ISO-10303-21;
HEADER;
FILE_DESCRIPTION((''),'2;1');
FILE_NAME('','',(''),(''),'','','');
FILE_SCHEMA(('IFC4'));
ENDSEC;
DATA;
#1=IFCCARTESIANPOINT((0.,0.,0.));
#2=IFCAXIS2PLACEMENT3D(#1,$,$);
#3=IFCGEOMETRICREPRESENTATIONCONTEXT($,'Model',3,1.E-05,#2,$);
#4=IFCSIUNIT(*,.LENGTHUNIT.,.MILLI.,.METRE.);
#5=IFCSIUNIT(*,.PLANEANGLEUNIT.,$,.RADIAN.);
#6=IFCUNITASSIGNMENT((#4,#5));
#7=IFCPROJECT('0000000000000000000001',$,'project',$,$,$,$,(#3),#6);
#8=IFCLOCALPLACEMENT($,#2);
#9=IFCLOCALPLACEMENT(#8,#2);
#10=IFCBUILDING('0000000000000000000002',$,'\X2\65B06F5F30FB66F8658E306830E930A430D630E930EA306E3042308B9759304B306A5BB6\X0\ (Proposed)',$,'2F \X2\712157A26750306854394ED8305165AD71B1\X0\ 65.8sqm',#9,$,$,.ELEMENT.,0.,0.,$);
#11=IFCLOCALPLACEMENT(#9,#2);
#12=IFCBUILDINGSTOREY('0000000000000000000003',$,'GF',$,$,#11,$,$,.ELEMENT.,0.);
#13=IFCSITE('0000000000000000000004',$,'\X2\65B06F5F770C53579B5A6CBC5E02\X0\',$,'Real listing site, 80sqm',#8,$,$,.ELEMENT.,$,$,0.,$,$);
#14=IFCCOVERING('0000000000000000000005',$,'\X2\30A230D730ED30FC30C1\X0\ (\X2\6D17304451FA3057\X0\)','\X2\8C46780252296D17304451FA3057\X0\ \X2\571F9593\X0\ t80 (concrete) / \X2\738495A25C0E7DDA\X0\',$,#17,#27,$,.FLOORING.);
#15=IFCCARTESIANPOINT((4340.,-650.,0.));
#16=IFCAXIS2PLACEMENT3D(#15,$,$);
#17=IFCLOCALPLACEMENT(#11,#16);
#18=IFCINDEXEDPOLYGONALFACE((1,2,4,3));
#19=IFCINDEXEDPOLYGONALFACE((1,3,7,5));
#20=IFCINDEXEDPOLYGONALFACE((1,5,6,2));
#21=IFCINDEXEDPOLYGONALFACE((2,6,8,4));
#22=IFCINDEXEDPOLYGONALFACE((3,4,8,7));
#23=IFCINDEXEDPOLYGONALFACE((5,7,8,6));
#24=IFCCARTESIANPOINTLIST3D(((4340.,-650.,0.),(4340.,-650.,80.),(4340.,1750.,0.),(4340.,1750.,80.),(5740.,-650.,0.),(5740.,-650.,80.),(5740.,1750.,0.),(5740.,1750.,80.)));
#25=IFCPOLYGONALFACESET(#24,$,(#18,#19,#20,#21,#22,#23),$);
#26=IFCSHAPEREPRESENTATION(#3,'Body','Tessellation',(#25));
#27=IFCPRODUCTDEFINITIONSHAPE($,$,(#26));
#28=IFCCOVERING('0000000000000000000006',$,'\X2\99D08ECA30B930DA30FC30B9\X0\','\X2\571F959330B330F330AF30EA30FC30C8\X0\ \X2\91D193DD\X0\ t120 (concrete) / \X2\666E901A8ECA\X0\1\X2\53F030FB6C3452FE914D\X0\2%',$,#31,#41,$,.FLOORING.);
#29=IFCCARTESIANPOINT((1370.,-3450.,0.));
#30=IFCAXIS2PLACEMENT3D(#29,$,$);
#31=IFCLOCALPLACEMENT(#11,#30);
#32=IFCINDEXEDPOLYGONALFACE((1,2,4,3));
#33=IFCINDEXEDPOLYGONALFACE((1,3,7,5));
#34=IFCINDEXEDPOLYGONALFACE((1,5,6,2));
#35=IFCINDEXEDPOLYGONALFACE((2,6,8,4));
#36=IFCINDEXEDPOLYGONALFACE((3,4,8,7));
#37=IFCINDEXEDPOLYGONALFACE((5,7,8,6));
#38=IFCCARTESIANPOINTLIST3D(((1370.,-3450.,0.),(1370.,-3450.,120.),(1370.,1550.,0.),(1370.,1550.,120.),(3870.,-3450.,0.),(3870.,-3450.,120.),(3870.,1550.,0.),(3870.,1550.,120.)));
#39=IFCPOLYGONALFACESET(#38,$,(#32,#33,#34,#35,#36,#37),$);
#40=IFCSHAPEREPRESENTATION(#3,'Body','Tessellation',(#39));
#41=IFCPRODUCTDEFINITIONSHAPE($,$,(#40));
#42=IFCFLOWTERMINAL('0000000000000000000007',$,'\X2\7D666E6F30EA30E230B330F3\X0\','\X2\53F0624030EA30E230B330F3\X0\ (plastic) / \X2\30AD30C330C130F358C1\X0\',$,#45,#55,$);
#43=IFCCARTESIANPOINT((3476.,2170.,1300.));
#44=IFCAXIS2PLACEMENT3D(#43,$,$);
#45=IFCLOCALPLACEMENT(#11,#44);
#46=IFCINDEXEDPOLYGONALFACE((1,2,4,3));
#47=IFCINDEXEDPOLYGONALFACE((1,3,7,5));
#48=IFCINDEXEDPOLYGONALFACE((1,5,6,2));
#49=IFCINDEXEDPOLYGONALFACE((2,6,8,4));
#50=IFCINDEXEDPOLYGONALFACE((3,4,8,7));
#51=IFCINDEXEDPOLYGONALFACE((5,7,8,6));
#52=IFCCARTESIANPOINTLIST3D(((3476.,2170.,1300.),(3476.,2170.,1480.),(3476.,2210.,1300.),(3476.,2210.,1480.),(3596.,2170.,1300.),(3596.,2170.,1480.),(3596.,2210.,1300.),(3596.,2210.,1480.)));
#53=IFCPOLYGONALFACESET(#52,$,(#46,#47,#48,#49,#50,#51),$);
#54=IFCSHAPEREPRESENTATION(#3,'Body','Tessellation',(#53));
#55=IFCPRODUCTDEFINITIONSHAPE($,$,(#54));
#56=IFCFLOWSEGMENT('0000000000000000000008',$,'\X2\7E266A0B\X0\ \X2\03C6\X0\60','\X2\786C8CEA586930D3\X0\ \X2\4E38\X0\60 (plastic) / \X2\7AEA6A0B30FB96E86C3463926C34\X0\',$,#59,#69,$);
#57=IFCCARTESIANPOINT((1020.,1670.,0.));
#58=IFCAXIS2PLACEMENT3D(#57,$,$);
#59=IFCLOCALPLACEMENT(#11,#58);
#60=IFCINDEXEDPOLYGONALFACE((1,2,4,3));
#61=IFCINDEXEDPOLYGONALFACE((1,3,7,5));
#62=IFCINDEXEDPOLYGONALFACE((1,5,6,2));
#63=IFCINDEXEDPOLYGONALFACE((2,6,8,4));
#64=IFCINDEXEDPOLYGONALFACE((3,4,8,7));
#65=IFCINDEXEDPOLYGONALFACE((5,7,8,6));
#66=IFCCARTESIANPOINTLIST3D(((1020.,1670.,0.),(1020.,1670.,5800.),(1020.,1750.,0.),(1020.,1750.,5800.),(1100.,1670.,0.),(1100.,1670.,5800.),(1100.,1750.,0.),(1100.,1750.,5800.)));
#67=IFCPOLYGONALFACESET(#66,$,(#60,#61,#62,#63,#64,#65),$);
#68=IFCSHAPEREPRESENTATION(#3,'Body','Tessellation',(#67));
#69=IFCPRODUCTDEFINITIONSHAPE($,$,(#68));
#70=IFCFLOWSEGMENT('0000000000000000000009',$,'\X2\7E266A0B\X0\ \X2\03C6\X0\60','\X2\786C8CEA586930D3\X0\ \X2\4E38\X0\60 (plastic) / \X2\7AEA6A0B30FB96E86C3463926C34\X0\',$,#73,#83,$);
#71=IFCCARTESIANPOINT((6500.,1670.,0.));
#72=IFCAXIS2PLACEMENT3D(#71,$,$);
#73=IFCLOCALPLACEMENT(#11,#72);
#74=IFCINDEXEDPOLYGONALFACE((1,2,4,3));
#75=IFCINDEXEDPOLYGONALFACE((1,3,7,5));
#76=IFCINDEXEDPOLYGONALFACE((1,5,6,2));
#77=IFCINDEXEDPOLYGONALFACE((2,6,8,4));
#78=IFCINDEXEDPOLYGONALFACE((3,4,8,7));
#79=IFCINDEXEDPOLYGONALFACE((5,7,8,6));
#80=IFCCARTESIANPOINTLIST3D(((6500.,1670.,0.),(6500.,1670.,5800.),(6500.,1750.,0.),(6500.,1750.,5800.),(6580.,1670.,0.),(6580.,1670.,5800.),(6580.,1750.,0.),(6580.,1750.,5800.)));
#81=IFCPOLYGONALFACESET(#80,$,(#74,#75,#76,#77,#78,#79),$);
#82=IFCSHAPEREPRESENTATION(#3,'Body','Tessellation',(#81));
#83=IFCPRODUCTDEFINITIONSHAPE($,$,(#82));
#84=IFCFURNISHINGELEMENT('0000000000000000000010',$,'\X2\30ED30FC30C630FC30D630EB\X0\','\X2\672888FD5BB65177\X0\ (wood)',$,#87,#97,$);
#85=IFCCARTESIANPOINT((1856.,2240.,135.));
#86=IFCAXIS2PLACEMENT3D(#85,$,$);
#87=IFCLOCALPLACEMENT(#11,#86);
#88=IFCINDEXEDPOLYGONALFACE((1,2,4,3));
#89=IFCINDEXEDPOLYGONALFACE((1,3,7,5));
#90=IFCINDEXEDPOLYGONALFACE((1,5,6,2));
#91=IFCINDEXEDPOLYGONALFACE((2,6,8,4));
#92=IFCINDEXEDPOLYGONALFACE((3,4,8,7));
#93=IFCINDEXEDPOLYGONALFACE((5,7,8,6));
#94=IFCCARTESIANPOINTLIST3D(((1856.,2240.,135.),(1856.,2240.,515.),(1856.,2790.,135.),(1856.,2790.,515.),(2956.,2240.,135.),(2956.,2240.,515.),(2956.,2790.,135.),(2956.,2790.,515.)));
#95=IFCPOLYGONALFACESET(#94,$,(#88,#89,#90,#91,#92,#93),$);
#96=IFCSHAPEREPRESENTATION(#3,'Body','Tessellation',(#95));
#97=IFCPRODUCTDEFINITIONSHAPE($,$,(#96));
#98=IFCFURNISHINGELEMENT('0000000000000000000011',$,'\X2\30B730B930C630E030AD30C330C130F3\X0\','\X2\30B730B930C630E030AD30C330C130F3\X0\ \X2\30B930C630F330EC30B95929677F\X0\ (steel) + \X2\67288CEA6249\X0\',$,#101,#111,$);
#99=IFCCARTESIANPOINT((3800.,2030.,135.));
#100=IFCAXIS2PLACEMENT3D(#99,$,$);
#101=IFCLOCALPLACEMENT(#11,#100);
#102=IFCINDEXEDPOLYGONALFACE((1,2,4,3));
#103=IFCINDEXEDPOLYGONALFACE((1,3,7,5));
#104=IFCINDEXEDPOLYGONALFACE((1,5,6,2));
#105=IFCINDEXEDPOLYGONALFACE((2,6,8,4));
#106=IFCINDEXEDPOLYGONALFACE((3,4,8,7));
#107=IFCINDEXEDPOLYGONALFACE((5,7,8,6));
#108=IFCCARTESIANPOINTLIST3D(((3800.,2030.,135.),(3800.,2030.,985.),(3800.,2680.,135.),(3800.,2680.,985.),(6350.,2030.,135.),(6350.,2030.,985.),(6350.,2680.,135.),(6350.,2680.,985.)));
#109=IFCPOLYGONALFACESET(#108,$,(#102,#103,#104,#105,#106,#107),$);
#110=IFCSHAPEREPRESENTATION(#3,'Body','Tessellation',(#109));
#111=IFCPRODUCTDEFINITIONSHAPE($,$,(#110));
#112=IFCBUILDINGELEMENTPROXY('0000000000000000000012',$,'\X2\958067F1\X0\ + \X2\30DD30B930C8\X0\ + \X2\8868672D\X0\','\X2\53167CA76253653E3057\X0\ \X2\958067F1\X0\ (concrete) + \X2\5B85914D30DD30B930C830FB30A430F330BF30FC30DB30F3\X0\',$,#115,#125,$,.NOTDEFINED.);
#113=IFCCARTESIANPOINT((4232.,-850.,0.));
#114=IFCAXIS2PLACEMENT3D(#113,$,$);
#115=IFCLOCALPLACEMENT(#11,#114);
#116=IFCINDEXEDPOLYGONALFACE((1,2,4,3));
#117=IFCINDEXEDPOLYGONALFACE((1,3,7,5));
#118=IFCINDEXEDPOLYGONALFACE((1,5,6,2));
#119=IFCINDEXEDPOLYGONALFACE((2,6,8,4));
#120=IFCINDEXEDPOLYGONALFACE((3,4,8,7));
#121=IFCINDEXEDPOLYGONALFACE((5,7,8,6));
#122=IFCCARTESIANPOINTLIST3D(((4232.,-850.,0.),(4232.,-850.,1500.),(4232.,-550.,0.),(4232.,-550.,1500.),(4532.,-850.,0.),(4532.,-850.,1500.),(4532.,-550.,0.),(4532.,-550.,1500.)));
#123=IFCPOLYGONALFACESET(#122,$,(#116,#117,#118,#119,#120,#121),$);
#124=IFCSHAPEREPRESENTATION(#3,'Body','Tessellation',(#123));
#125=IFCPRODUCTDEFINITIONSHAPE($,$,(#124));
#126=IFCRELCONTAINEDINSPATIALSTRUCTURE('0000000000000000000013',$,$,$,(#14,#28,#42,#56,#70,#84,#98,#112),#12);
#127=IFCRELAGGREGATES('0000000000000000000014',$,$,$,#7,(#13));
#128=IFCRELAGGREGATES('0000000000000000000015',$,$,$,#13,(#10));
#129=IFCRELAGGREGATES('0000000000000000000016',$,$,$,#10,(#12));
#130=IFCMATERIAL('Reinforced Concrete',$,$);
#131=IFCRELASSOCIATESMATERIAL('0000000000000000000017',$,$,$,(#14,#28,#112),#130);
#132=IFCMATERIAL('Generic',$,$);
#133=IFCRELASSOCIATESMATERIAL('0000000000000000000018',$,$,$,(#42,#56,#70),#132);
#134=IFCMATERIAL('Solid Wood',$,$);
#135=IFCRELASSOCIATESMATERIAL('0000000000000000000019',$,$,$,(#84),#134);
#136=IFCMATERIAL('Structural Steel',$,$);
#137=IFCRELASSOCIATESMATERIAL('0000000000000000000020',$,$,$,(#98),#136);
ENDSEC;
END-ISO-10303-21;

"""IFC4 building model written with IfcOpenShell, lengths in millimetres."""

from ifc_helpers import new_model, si_unit, frame, frame_2d, origin, place, context, project, spatial, rectangle, extrude, material, element, save


model = new_model("IFC4")

# Units and contexts
model_context = context("Model", 3, precision=1e-05, world=origin())
ifc_project = project(units=[si_unit("LENGTHUNIT", "METRE", prefix="MILLI"), si_unit("PLANEANGLEUNIT", "RADIAN")], contexts=[model_context])

# Site, building, storey
site_placement = place(None, origin())
site = spatial("IfcSite", under=ifc_project, at=site_placement, Name="新潟県南魚沼市", ObjectType="Real listing site, 80sqm", CompositionType="ELEMENT", RefElevation=0.0)
building_placement = place(site_placement, origin())
building = spatial("IfcBuilding", under=site, at=building_placement, Name="新潟・書斎とライブラリのある静かな家 (Proposed)", ObjectType="2F 無垢材と吹付け断熱 65.8sqm", CompositionType="ELEMENT", ElevationOfRefHeight=0.0, ElevationOfTerrain=0.0)
storey_placement = place(building_placement, origin())
storey = spatial("IfcBuildingStorey", under=building, at=storey_placement, Name="GF", CompositionType="ELEMENT", Elevation=0.0)

# Shared definitions
ifc_material_1 = material(Name="Solid Wood")

# Shared definitions
ifc_material_2 = material(Name="Reinforced Concrete")

# Coverings
ifc_material_3 = material(Name="Generic")
covering_1_placement = place(storey_placement, frame((4340.0, -650.0, 0.0)))
element("IfcCovering", 1, at=covering_1_placement, inside=storey, material=ifc_material_2, Name="アプローチ (洗い出し)", Description="豆砂利洗い出し 土間 t80 (concrete) / 玄関導線", PredefinedType="FLOORING", context=model_context, shape_type="SweptSolid", body=[
    extrude(rectangle(XDim=1400.0, YDim=2400.0, at=frame_2d((700.0, 1200.0))), frame((4340.0, -650.0, 0.0)), (0.0, 0.0, 1.0), 80.0),
])
covering_2_placement = place(storey_placement, frame((1370.0, -3450.0, 0.0)))
element("IfcCovering", 2, at=covering_2_placement, inside=storey, material=ifc_material_2, Name="駐車スペース", Description="土間コンクリート 金鏝 t120 (concrete) / 普通車1台・水勾配2%", PredefinedType="FLOORING", context=model_context, shape_type="SweptSolid", body=[
    extrude(rectangle(XDim=2500.0, YDim=5000.0, at=frame_2d((1250.0, 2500.0))), frame((1370.0, -3450.0, 0.0)), (0.0, 0.0, 1.0), 120.0),
])

# Flow terminal
flow_terminal_placement = place(storey_placement, frame((3476.0, 2170.0, 1300.0)))
element("IfcFlowTerminal", 3, at=flow_terminal_placement, inside=storey, material=ifc_material_3, Name="給湯リモコン", Description="台所リモコン (plastic) / キッチン壁", context=model_context, shape_type="SweptSolid", body=[
    extrude(rectangle(XDim=120.0, YDim=40.0, at=frame_2d((60.0, 20.0))), frame((3476.0, 2170.0, 1300.0)), (0.0, 0.0, 1.0), 180.0),
])

# Flow segments
flow_segment_1_placement = place(storey_placement, frame((1020.0, 1670.0, 0.0)))
element("IfcFlowSegment", 4, at=flow_segment_1_placement, inside=storey, material=ifc_material_3, Name="縦樋 φ60", Description="硬質塩ビ 丸60 (plastic) / 竪樋・雨水排水", context=model_context, shape_type="SweptSolid", body=[
    extrude(rectangle(XDim=80.0, YDim=80.0, at=frame_2d((40.0, 40.0))), frame((1020.0, 1670.0, 0.0)), (0.0, 0.0, 1.0), 5800.0),
])
flow_segment_2_placement = place(storey_placement, frame((6500.0, 1670.0, 0.0)))
element("IfcFlowSegment", 5, at=flow_segment_2_placement, inside=storey, material=ifc_material_3, Name="縦樋 φ60", Description="硬質塩ビ 丸60 (plastic) / 竪樋・雨水排水", context=model_context, shape_type="SweptSolid", body=[
    extrude(rectangle(XDim=80.0, YDim=80.0, at=frame_2d((40.0, 40.0))), frame((6500.0, 1670.0, 0.0)), (0.0, 0.0, 1.0), 5800.0),
])

# Furnishing elements
furnishing_1_placement = place(storey_placement, frame((1856.0, 2240.0, 135.0)))
element("IfcFurnishingElement", 6, at=furnishing_1_placement, inside=storey, material=ifc_material_1, Name="ローテーブル", Description="木製家具 (wood)", context=model_context, shape_type="SweptSolid", body=[
    extrude(rectangle(XDim=1100.0, YDim=550.0, at=frame_2d((550.0, 275.0))), frame((1856.0, 2240.0, 135.0)), (0.0, 0.0, 1.0), 380.0),
])
ifc_material_4 = material(Name="Structural Steel")
furnishing_2_placement = place(storey_placement, frame((3800.0, 2030.0, 135.0)))
element("IfcFurnishingElement", 7, at=furnishing_2_placement, inside=storey, material=ifc_material_4, Name="システムキッチン", Description="システムキッチン ステンレス天板 (steel) + 木質扉", context=model_context, shape_type="SweptSolid", body=[
    extrude(rectangle(XDim=2550.0, YDim=650.0, at=frame_2d((1275.0, 325.0))), frame((3800.0, 2030.0, 135.0)), (0.0, 0.0, 1.0), 850.0),
])

# Building element proxy
proxy_placement = place(storey_placement, frame((4232.0, -850.0, 0.0)))
element("IfcBuildingElementProxy", 8, at=proxy_placement, inside=storey, material=ifc_material_2, Name="門柱 + ポスト + 表札", Description="化粧打放し 門柱 (concrete) + 宅配ポスト・インターホン", PredefinedType="NOTDEFINED", context=model_context, shape_type="SweptSolid", body=[
    extrude(rectangle(XDim=300.0, YDim=300.0, at=frame_2d((150.0, 150.0))), frame((4232.0, -850.0, 0.0)), (0.0, 0.0, 1.0), 1500.0),
])

save(model, "model.ifc")
